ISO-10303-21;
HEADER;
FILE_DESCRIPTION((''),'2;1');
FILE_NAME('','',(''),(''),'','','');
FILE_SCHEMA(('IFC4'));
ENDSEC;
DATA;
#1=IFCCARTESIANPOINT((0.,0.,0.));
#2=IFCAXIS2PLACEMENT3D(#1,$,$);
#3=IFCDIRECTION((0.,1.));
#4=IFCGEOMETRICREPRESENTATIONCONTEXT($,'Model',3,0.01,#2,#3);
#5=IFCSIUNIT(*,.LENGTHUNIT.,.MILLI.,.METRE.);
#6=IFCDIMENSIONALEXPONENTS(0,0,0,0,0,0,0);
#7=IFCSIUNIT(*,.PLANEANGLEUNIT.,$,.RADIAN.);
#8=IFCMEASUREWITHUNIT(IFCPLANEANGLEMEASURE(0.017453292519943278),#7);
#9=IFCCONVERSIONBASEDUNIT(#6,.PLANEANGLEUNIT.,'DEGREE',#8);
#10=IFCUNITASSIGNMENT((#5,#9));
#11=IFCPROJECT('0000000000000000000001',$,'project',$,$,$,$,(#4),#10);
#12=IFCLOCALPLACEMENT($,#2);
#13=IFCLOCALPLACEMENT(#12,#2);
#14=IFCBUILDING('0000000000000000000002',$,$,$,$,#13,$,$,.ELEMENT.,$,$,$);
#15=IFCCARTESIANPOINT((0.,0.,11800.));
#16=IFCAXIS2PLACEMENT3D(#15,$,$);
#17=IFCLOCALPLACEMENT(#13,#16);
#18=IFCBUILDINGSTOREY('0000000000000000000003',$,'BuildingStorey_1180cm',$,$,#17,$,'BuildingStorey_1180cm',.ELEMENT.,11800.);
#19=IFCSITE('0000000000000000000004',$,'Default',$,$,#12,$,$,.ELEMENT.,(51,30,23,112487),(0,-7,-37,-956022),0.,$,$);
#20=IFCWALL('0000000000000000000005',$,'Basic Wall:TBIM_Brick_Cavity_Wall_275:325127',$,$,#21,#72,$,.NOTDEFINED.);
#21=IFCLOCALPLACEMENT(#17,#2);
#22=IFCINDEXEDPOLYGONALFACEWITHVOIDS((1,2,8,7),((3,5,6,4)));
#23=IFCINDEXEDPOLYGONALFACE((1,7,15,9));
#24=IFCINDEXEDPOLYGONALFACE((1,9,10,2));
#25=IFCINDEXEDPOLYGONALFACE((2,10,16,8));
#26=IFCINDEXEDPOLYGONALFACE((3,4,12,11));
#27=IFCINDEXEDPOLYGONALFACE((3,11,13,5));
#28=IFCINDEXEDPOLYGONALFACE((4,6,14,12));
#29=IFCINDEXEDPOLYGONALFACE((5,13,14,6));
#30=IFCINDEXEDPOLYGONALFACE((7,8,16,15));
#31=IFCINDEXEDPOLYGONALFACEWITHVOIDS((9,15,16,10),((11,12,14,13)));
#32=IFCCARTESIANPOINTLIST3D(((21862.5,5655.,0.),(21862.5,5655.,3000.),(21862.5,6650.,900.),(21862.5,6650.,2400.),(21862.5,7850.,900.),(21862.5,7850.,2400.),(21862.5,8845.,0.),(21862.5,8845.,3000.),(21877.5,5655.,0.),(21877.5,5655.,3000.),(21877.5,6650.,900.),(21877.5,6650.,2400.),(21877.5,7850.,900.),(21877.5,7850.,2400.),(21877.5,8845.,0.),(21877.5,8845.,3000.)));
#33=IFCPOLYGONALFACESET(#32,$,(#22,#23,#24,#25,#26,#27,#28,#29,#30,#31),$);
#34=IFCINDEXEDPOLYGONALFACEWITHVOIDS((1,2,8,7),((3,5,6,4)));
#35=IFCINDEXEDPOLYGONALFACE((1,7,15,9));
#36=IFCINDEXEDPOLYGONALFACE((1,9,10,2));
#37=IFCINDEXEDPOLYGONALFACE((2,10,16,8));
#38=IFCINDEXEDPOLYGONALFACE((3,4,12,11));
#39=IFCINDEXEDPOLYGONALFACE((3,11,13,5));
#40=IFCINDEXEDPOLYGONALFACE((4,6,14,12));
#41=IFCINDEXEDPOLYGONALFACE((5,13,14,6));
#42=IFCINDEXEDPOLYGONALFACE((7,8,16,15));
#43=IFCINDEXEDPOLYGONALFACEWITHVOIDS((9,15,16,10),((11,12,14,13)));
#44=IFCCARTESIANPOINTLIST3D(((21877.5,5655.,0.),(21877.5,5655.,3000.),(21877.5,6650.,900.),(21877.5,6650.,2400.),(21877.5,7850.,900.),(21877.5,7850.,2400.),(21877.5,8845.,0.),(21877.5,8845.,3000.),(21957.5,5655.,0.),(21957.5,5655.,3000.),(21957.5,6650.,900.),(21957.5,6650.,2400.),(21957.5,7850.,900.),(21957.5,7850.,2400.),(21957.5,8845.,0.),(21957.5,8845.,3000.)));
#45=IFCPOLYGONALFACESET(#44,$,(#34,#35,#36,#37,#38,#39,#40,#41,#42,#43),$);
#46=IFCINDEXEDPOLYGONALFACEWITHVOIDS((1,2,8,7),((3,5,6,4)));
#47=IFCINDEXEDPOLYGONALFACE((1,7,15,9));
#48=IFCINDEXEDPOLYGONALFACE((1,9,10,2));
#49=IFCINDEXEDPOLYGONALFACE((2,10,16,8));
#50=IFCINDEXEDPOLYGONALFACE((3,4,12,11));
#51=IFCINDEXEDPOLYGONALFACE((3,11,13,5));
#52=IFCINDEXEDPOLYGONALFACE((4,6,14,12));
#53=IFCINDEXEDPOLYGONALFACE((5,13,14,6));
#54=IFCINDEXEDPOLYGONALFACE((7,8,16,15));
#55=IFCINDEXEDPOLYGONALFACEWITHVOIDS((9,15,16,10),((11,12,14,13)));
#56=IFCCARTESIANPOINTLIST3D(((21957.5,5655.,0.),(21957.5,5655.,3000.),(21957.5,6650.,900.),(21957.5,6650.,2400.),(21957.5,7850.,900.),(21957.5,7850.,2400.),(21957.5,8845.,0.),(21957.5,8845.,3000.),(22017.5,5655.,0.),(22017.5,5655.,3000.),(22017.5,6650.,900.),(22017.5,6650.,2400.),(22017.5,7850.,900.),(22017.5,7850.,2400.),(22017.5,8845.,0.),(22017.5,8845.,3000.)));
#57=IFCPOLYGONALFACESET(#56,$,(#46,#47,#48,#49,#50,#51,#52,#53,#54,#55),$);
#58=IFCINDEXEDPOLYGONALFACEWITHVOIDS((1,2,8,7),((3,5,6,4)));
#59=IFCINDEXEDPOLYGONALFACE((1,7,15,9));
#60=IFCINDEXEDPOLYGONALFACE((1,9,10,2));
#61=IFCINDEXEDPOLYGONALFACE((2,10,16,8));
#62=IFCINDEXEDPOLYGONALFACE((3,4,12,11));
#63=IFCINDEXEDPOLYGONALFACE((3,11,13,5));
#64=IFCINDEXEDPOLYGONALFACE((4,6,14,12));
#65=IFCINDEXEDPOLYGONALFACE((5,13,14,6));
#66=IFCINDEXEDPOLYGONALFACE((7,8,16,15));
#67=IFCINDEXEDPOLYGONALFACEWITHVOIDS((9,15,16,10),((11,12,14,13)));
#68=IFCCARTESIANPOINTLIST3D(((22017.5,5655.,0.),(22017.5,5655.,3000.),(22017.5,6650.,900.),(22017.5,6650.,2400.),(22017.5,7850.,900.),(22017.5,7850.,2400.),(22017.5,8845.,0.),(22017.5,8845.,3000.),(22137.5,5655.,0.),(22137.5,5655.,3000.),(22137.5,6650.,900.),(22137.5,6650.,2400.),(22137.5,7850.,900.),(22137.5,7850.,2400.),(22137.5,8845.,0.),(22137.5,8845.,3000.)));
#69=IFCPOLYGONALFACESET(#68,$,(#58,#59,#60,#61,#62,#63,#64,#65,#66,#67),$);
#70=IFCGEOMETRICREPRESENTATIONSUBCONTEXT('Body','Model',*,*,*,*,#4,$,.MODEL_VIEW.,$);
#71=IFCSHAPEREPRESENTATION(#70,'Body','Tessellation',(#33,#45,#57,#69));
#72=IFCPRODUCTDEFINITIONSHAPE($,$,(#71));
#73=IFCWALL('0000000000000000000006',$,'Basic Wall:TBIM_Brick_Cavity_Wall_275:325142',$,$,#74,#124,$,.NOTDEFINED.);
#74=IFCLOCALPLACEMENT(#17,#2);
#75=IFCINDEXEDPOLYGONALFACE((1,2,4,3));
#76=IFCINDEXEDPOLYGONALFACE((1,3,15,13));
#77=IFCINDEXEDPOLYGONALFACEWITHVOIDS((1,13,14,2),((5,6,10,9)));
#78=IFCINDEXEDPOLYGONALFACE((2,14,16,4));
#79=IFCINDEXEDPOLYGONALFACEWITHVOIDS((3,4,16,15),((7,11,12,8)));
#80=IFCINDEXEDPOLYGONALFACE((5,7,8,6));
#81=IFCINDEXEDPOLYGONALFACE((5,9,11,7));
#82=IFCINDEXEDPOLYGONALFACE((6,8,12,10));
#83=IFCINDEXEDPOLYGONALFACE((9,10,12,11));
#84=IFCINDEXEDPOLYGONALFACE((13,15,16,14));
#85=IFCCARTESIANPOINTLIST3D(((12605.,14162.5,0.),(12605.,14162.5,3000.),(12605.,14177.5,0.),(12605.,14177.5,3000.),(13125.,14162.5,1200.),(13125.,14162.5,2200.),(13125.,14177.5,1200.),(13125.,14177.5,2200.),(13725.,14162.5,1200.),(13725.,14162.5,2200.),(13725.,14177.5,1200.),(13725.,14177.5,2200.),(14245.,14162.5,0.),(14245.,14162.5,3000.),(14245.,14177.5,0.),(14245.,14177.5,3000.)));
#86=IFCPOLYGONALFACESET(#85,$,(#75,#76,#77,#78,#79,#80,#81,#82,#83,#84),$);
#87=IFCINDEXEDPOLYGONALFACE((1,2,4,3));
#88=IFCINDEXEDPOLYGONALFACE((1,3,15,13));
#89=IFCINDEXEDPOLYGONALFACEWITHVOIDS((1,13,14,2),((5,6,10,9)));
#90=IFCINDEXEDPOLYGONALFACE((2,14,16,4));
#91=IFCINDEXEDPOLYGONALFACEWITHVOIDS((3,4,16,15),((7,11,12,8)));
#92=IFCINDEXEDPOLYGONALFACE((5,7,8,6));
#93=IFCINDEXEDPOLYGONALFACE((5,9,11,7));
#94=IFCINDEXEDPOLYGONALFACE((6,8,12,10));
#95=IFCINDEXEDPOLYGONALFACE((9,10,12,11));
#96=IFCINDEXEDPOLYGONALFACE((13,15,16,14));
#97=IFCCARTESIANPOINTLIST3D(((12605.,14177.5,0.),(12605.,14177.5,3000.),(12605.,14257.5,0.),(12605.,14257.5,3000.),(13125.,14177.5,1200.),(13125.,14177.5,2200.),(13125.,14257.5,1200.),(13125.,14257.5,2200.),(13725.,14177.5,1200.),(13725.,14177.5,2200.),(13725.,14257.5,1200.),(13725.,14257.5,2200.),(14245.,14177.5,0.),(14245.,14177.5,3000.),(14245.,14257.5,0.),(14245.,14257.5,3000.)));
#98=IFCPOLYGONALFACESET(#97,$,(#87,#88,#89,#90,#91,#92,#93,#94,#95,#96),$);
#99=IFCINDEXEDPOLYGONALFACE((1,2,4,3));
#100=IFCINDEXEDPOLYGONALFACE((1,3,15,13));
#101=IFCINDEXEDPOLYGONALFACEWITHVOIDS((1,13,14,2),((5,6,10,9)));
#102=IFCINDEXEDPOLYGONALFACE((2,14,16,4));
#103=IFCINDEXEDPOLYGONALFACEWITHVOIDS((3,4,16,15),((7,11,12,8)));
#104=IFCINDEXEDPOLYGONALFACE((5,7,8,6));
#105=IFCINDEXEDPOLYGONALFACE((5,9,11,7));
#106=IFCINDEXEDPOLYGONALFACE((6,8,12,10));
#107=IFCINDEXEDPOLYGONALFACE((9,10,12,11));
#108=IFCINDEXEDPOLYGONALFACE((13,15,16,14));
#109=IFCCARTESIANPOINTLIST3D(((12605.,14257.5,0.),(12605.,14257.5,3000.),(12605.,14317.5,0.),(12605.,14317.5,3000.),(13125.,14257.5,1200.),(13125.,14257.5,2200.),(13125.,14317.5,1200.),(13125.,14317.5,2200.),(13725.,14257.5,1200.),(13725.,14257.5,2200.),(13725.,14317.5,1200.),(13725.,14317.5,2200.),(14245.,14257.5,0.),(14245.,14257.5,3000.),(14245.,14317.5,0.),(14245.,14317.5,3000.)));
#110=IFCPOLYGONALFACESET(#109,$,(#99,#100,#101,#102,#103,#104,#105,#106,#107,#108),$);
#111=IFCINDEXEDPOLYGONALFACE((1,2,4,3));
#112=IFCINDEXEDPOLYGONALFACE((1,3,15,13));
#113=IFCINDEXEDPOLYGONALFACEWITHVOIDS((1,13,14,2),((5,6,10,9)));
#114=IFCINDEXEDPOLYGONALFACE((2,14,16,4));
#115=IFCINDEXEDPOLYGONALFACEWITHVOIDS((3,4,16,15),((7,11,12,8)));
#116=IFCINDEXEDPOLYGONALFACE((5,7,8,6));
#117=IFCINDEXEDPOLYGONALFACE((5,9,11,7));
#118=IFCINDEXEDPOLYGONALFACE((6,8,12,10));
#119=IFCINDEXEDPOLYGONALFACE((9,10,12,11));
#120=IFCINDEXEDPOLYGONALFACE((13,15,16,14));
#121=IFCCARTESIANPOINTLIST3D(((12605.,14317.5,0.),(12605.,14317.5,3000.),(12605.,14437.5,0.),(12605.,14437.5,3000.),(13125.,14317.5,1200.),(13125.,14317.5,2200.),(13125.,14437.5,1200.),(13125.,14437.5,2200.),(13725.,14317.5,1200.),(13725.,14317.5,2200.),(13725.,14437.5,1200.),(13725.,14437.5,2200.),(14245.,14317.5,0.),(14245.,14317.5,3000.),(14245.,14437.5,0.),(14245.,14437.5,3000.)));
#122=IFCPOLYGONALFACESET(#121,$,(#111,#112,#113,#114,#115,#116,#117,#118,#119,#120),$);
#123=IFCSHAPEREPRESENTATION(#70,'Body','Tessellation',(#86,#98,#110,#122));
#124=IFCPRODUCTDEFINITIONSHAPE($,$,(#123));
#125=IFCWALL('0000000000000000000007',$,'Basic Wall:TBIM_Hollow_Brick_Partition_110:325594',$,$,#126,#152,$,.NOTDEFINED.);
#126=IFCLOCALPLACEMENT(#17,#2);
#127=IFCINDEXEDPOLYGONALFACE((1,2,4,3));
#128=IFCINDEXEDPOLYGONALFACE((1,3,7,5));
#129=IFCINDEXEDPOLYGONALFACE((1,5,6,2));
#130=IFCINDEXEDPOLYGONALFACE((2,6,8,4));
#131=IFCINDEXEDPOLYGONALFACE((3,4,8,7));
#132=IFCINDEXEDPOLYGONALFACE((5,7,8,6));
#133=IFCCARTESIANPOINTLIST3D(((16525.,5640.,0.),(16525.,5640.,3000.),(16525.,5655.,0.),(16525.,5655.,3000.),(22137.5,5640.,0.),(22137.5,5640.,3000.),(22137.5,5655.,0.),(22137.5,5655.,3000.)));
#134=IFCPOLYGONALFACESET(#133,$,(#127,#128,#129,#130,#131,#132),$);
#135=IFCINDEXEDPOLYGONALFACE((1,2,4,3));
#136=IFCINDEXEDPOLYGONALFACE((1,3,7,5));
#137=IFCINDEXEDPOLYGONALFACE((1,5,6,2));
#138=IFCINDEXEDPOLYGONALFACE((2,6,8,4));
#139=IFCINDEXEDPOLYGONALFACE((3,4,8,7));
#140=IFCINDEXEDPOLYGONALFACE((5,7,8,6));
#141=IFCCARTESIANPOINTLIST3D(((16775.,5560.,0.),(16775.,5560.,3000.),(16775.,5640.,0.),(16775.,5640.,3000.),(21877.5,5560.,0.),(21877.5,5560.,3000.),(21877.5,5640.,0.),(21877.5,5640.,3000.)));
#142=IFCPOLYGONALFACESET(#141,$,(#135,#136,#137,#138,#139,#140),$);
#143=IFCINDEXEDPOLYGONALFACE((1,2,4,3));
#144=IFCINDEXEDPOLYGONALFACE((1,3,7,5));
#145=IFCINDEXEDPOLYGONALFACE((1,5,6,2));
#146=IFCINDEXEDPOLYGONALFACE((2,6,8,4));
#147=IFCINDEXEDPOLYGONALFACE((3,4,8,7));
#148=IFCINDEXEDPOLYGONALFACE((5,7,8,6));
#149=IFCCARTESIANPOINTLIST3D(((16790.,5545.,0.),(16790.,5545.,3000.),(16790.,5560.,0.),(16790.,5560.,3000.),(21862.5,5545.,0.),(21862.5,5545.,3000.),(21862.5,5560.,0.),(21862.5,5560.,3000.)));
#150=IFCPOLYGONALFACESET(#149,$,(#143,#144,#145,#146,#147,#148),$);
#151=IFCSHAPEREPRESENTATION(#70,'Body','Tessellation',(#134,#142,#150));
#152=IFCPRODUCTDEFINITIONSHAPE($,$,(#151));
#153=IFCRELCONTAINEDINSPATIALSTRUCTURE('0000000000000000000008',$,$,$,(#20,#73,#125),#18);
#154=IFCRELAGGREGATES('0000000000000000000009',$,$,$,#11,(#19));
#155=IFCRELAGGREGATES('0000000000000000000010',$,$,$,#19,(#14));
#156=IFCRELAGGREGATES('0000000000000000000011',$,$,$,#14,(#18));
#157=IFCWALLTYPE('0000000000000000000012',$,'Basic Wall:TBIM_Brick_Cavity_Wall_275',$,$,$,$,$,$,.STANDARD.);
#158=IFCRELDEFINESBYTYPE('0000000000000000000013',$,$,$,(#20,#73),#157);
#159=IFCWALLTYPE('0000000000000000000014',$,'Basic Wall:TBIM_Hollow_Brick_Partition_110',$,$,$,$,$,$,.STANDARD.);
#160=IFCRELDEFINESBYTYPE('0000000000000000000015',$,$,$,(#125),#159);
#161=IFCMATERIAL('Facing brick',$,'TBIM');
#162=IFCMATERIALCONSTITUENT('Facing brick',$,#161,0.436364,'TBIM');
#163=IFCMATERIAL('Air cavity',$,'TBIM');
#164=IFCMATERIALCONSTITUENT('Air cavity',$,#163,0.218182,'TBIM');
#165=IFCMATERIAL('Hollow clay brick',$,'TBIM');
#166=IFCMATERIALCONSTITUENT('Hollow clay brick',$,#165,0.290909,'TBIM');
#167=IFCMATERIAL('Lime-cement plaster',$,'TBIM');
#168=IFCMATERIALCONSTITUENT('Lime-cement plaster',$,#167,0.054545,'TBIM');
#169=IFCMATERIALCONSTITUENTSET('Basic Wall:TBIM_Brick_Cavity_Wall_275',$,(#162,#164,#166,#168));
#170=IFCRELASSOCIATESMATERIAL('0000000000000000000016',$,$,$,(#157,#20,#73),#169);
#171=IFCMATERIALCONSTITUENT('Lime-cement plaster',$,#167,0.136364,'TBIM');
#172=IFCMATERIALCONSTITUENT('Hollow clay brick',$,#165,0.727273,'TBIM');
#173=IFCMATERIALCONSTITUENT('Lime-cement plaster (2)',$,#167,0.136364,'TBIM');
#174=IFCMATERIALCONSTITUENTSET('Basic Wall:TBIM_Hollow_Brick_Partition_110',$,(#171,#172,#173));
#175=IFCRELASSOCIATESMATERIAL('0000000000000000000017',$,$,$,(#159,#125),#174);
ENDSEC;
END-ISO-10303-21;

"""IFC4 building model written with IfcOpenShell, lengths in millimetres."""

from ifc_helpers import new_model, entity, si_unit, converted_unit, direction, frame, origin, place, context, subcontext, project, spatial, indexed_curve, outline, extrude, material, constituent, constituent_set, type_object, element, save


model = new_model("IFC4")

# Units and contexts
model_context = context("Model", 3, precision=0.01, world=origin(), true_north=direction((0.0, 1.0)))
body_context = subcontext(model_context, "Body", "Model", "MODEL_VIEW")
ifc_project = project(units=[si_unit("LENGTHUNIT", "METRE", prefix="MILLI"), converted_unit("PLANEANGLEUNIT", "DEGREE", entity("IfcPlaneAngleMeasure", 0.017453292519943278), si_unit("PLANEANGLEUNIT", "RADIAN"), dimensions=[0, 0, 0, 0, 0, 0, 0])], contexts=[model_context])

# Site, building, storey
site_placement = place(None, origin())
site = spatial("IfcSite", under=ifc_project, at=site_placement, Name="Default", CompositionType="ELEMENT", RefLatitude=(51, 30, 23, 112487), RefLongitude=(0, -7, -37, -956022), RefElevation=0.0)
building_placement = place(site_placement, origin())
building = spatial("IfcBuilding", under=site, at=building_placement, CompositionType="ELEMENT")
storey_placement = place(building_placement, frame((0.0, 0.0, 11800.0)))
storey = spatial("IfcBuildingStorey", under=building, at=storey_placement, Name="BuildingStorey_1180cm", LongName="BuildingStorey_1180cm", CompositionType="ELEMENT", Elevation=11800.0)

# Walls, openings
ifc_material_1 = material(Name="Facing brick", Category="TBIM")
ifc_constituent_1 = constituent(ifc_material_1, Name="Facing brick", Category="TBIM", fraction=0.436364)
ifc_material_2 = material(Name="Air cavity", Category="TBIM")
ifc_constituent_2 = constituent(ifc_material_2, Name="Air cavity", Category="TBIM", fraction=0.218182)
ifc_material_3 = material(Name="Hollow clay brick", Category="TBIM")
ifc_constituent_3 = constituent(ifc_material_3, Name="Hollow clay brick", Category="TBIM", fraction=0.290909)
ifc_material_4 = material(Name="Lime-cement plaster", Category="TBIM")
ifc_constituent_4 = constituent(ifc_material_4, Name="Lime-cement plaster", Category="TBIM", fraction=0.054545)
ifc_constituent_set_1 = constituent_set(constituents=[ifc_constituent_1, ifc_constituent_2, ifc_constituent_3, ifc_constituent_4], Name="Basic Wall:TBIM_Brick_Cavity_Wall_275")
wall_type_1 = type_object("IfcWallType", Name="Basic Wall:TBIM_Brick_Cavity_Wall_275", PredefinedType="STANDARD", material=ifc_constituent_set_1)
wall_1_placement = place(storey_placement, frame((22000.0, 5655.0, 0.0), z_axis=(0.0, 0.0, 1.0), x_axis=(0.0, 1.0, 0.0)))
wall_1 = element("IfcWall", 1, at=wall_1_placement, inside=storey, type_object=wall_type_1, material=ifc_constituent_set_1, Name="Basic Wall:TBIM_Brick_Cavity_Wall_275:325127", PredefinedType="NOTDEFINED", context=body_context, shape_type="SweptSolid", body=[
    extrude(outline(indexed_curve([(-1595.0, -1500.0), (1595.0, -1500.0), (1595.0, 1500.0), (-1595.0, 1500.0), (-1595.0, -1500.0)], self_intersect=False), holes=[indexed_curve([(-600.0, 900.0), (600.0, 900.0), (600.0, -600.0), (-600.0, -600.0), (-600.0, 900.0)], self_intersect=False)]), frame((1595.0, 137.5, 1500.0), z_axis=(0.0, -1.0, 0.0), x_axis=(1.0, 0.0, 0.0)), (0.0, 0.0, 1.0), 15.0),
    extrude(outline(indexed_curve([(-1500.0, -1595.0), (1500.0, -1595.0), (1500.0, 1595.0), (-1500.0, 1595.0), (-1500.0, -1595.0)], self_intersect=False), holes=[indexed_curve([(900.0, 600.0), (900.0, -600.0), (-600.0, -600.0), (-600.0, 600.0), (900.0, 600.0)], self_intersect=False)]), frame((1595.0, 122.5, 1500.0), z_axis=(0.0, -1.0, 0.0), x_axis=(0.0, 0.0, 1.0)), (0.0, 0.0, 1.0), 80.0),
    extrude(outline(indexed_curve([(-1500.0, -1595.0), (1500.0, -1595.0), (1500.0, 1595.0), (-1500.0, 1595.0), (-1500.0, -1595.0)], self_intersect=False), holes=[indexed_curve([(900.0, 600.0), (900.0, -600.0), (-600.0, -600.0), (-600.0, 600.0), (900.0, 600.0)], self_intersect=False)]), frame((1595.0, 42.5, 1500.0), z_axis=(0.0, -1.0, 0.0), x_axis=(0.0, 0.0, 1.0)), (0.0, 0.0, 1.0), 60.0),
    extrude(outline(indexed_curve([(-1500.0, -1595.0), (1500.0, -1595.0), (1500.0, 1595.0), (-1500.0, 1595.0), (-1500.0, -1595.0)], self_intersect=False), holes=[indexed_curve([(900.0, 600.0), (900.0, -600.0), (-600.0, -600.0), (-600.0, 600.0), (900.0, 600.0)], self_intersect=False)]), frame((1595.0, -17.5, 1500.0), z_axis=(0.0, -1.0, 0.0), x_axis=(0.0, 0.0, 1.0)), (0.0, 0.0, 1.0), 120.0),
])
opening_1_placement = place(wall_1_placement, frame((995.0, -137.5, 900.0)))
element("IfcOpeningElement", 2, at=opening_1_placement, cuts=wall_1, PredefinedType="OPENING", context=body_context, shape_type="SweptSolid", body=[
    extrude(outline(indexed_curve([(1500.0, 0.0), (1500.0, 1200.0), (0.0, 1200.0), (0.0, 0.0), (1500.0, 0.0)], self_intersect=False)), frame((0.0, 0.0, 0.0), z_axis=(0.0, 1.0, 0.0), x_axis=(0.0, 0.0, 1.0)), (0.0, 0.0, 1.0), 275.0),
])
wall_2_placement = place(storey_placement, frame((14245.0, 14300.0, 0.0), z_axis=(0.0, 0.0, 1.0), x_axis=(-1.0, 0.0, 0.0)))
wall_2 = element("IfcWall", 3, at=wall_2_placement, inside=storey, type_object=wall_type_1, material=ifc_constituent_set_1, Name="Basic Wall:TBIM_Brick_Cavity_Wall_275:325142", PredefinedType="NOTDEFINED", context=body_context, shape_type="SweptSolid", body=[
    extrude(outline(indexed_curve([(-820.0, -1500.0), (820.0, -1500.0), (820.0, 1500.0), (-820.0, 1500.0), (-820.0, -1500.0)], self_intersect=False), holes=[indexed_curve([(-300.0, 700.0), (300.0, 700.0), (300.0, -300.0), (-300.0, -300.0), (-300.0, 700.0)], self_intersect=False)]), frame((820.0, 137.5, 1500.0), z_axis=(0.0, -1.0, 0.0), x_axis=(1.0, 0.0, 0.0)), (0.0, 0.0, 1.0), 15.0),
    extrude(outline(indexed_curve([(-1500.0, -820.0), (1500.0, -820.0), (1500.0, 820.0), (-1500.0, 820.0), (-1500.0, -820.0)], self_intersect=False), holes=[indexed_curve([(700.0, 300.0), (700.0, -300.0), (-300.0, -300.0), (-300.0, 300.0), (700.0, 300.0)], self_intersect=False)]), frame((820.0, 122.5, 1500.0), z_axis=(0.0, -1.0, 0.0), x_axis=(0.0, 0.0, 1.0)), (0.0, 0.0, 1.0), 80.0),
    extrude(outline(indexed_curve([(-1500.0, -820.0), (1500.0, -820.0), (1500.0, 820.0), (-1500.0, 820.0), (-1500.0, -820.0)], self_intersect=False), holes=[indexed_curve([(700.0, 300.0), (700.0, -300.0), (-300.0, -300.0), (-300.0, 300.0), (700.0, 300.0)], self_intersect=False)]), frame((820.0, 42.5, 1500.0), z_axis=(0.0, -1.0, 0.0), x_axis=(0.0, 0.0, 1.0)), (0.0, 0.0, 1.0), 60.0),
    extrude(outline(indexed_curve([(-1500.0, -820.0), (1500.0, -820.0), (1500.0, 820.0), (-1500.0, 820.0), (-1500.0, -820.0)], self_intersect=False), holes=[indexed_curve([(700.0, 300.0), (700.0, -300.0), (-300.0, -300.0), (-300.0, 300.0), (700.0, 300.0)], self_intersect=False)]), frame((820.0, -17.5, 1500.0), z_axis=(0.0, -1.0, 0.0), x_axis=(0.0, 0.0, 1.0)), (0.0, 0.0, 1.0), 120.0),
])
opening_2_placement = place(wall_2_placement, frame((520.0, -137.5, 1200.0)))
element("IfcOpeningElement", 4, at=opening_2_placement, cuts=wall_2, PredefinedType="OPENING", context=body_context, shape_type="SweptSolid", body=[
    extrude(outline(indexed_curve([(1000.0, 0.0), (1000.0, 600.0), (0.0, 600.0), (0.0, 0.0), (1000.0, 0.0)], self_intersect=False)), frame((0.0, 0.0, 0.0), z_axis=(0.0, 1.0, 0.0), x_axis=(0.0, 0.0, 1.0)), (0.0, 0.0, 1.0), 275.0),
])
ifc_constituent_5 = constituent(ifc_material_4, Name="Lime-cement plaster", Category="TBIM", fraction=0.136364)
ifc_constituent_6 = constituent(ifc_material_3, Name="Hollow clay brick", Category="TBIM", fraction=0.727273)
ifc_constituent_7 = constituent(ifc_material_4, Name="Lime-cement plaster (2)", Category="TBIM", fraction=0.136364)
ifc_constituent_set_2 = constituent_set(constituents=[ifc_constituent_5, ifc_constituent_6, ifc_constituent_7], Name="Basic Wall:TBIM_Hollow_Brick_Partition_110")
wall_type_2 = type_object("IfcWallType", Name="Basic Wall:TBIM_Hollow_Brick_Partition_110", PredefinedType="STANDARD", material=ifc_constituent_set_2)

# Wall
wall_3_placement = place(storey_placement, frame((16790.0, 5600.0, 0.0)))
element("IfcWall", 5, at=wall_3_placement, inside=storey, type_object=wall_type_2, material=ifc_constituent_set_2, Name="Basic Wall:TBIM_Hollow_Brick_Partition_110:325594", PredefinedType="NOTDEFINED", context=body_context, shape_type="SweptSolid", body=[
    extrude(outline(indexed_curve([(-7.5, -2806.3), (7.5, -2806.3), (7.5, 2806.3), (-7.5, 2806.3), (-7.5, -2806.3)], self_intersect=False)), frame((2541.3, 47.5, 0.0), z_axis=(0.0, 0.0, 1.0), x_axis=(0.0, -1.0, 0.0)), (0.0, 0.0, 1.0), 3000.0),
    extrude(outline(indexed_curve([(-2551.3, -40.0), (2551.3, -40.0), (2551.3, 40.0), (-2551.3, 40.0), (-2551.3, -40.0)], self_intersect=False)), frame((2536.3, 0.0, 0.0)), (0.0, 0.0, 1.0), 3000.0),
    extrude(outline(indexed_curve([(-7.5, -2536.3), (7.5, -2536.3), (7.5, 2536.3), (-7.5, 2536.3), (-7.5, -2536.3)], self_intersect=False)), frame((2536.3, -47.5, 0.0), z_axis=(0.0, 0.0, 1.0), x_axis=(0.0, 1.0, 0.0)), (0.0, 0.0, 1.0), 3000.0),
])

save(model, "model.ifc")
